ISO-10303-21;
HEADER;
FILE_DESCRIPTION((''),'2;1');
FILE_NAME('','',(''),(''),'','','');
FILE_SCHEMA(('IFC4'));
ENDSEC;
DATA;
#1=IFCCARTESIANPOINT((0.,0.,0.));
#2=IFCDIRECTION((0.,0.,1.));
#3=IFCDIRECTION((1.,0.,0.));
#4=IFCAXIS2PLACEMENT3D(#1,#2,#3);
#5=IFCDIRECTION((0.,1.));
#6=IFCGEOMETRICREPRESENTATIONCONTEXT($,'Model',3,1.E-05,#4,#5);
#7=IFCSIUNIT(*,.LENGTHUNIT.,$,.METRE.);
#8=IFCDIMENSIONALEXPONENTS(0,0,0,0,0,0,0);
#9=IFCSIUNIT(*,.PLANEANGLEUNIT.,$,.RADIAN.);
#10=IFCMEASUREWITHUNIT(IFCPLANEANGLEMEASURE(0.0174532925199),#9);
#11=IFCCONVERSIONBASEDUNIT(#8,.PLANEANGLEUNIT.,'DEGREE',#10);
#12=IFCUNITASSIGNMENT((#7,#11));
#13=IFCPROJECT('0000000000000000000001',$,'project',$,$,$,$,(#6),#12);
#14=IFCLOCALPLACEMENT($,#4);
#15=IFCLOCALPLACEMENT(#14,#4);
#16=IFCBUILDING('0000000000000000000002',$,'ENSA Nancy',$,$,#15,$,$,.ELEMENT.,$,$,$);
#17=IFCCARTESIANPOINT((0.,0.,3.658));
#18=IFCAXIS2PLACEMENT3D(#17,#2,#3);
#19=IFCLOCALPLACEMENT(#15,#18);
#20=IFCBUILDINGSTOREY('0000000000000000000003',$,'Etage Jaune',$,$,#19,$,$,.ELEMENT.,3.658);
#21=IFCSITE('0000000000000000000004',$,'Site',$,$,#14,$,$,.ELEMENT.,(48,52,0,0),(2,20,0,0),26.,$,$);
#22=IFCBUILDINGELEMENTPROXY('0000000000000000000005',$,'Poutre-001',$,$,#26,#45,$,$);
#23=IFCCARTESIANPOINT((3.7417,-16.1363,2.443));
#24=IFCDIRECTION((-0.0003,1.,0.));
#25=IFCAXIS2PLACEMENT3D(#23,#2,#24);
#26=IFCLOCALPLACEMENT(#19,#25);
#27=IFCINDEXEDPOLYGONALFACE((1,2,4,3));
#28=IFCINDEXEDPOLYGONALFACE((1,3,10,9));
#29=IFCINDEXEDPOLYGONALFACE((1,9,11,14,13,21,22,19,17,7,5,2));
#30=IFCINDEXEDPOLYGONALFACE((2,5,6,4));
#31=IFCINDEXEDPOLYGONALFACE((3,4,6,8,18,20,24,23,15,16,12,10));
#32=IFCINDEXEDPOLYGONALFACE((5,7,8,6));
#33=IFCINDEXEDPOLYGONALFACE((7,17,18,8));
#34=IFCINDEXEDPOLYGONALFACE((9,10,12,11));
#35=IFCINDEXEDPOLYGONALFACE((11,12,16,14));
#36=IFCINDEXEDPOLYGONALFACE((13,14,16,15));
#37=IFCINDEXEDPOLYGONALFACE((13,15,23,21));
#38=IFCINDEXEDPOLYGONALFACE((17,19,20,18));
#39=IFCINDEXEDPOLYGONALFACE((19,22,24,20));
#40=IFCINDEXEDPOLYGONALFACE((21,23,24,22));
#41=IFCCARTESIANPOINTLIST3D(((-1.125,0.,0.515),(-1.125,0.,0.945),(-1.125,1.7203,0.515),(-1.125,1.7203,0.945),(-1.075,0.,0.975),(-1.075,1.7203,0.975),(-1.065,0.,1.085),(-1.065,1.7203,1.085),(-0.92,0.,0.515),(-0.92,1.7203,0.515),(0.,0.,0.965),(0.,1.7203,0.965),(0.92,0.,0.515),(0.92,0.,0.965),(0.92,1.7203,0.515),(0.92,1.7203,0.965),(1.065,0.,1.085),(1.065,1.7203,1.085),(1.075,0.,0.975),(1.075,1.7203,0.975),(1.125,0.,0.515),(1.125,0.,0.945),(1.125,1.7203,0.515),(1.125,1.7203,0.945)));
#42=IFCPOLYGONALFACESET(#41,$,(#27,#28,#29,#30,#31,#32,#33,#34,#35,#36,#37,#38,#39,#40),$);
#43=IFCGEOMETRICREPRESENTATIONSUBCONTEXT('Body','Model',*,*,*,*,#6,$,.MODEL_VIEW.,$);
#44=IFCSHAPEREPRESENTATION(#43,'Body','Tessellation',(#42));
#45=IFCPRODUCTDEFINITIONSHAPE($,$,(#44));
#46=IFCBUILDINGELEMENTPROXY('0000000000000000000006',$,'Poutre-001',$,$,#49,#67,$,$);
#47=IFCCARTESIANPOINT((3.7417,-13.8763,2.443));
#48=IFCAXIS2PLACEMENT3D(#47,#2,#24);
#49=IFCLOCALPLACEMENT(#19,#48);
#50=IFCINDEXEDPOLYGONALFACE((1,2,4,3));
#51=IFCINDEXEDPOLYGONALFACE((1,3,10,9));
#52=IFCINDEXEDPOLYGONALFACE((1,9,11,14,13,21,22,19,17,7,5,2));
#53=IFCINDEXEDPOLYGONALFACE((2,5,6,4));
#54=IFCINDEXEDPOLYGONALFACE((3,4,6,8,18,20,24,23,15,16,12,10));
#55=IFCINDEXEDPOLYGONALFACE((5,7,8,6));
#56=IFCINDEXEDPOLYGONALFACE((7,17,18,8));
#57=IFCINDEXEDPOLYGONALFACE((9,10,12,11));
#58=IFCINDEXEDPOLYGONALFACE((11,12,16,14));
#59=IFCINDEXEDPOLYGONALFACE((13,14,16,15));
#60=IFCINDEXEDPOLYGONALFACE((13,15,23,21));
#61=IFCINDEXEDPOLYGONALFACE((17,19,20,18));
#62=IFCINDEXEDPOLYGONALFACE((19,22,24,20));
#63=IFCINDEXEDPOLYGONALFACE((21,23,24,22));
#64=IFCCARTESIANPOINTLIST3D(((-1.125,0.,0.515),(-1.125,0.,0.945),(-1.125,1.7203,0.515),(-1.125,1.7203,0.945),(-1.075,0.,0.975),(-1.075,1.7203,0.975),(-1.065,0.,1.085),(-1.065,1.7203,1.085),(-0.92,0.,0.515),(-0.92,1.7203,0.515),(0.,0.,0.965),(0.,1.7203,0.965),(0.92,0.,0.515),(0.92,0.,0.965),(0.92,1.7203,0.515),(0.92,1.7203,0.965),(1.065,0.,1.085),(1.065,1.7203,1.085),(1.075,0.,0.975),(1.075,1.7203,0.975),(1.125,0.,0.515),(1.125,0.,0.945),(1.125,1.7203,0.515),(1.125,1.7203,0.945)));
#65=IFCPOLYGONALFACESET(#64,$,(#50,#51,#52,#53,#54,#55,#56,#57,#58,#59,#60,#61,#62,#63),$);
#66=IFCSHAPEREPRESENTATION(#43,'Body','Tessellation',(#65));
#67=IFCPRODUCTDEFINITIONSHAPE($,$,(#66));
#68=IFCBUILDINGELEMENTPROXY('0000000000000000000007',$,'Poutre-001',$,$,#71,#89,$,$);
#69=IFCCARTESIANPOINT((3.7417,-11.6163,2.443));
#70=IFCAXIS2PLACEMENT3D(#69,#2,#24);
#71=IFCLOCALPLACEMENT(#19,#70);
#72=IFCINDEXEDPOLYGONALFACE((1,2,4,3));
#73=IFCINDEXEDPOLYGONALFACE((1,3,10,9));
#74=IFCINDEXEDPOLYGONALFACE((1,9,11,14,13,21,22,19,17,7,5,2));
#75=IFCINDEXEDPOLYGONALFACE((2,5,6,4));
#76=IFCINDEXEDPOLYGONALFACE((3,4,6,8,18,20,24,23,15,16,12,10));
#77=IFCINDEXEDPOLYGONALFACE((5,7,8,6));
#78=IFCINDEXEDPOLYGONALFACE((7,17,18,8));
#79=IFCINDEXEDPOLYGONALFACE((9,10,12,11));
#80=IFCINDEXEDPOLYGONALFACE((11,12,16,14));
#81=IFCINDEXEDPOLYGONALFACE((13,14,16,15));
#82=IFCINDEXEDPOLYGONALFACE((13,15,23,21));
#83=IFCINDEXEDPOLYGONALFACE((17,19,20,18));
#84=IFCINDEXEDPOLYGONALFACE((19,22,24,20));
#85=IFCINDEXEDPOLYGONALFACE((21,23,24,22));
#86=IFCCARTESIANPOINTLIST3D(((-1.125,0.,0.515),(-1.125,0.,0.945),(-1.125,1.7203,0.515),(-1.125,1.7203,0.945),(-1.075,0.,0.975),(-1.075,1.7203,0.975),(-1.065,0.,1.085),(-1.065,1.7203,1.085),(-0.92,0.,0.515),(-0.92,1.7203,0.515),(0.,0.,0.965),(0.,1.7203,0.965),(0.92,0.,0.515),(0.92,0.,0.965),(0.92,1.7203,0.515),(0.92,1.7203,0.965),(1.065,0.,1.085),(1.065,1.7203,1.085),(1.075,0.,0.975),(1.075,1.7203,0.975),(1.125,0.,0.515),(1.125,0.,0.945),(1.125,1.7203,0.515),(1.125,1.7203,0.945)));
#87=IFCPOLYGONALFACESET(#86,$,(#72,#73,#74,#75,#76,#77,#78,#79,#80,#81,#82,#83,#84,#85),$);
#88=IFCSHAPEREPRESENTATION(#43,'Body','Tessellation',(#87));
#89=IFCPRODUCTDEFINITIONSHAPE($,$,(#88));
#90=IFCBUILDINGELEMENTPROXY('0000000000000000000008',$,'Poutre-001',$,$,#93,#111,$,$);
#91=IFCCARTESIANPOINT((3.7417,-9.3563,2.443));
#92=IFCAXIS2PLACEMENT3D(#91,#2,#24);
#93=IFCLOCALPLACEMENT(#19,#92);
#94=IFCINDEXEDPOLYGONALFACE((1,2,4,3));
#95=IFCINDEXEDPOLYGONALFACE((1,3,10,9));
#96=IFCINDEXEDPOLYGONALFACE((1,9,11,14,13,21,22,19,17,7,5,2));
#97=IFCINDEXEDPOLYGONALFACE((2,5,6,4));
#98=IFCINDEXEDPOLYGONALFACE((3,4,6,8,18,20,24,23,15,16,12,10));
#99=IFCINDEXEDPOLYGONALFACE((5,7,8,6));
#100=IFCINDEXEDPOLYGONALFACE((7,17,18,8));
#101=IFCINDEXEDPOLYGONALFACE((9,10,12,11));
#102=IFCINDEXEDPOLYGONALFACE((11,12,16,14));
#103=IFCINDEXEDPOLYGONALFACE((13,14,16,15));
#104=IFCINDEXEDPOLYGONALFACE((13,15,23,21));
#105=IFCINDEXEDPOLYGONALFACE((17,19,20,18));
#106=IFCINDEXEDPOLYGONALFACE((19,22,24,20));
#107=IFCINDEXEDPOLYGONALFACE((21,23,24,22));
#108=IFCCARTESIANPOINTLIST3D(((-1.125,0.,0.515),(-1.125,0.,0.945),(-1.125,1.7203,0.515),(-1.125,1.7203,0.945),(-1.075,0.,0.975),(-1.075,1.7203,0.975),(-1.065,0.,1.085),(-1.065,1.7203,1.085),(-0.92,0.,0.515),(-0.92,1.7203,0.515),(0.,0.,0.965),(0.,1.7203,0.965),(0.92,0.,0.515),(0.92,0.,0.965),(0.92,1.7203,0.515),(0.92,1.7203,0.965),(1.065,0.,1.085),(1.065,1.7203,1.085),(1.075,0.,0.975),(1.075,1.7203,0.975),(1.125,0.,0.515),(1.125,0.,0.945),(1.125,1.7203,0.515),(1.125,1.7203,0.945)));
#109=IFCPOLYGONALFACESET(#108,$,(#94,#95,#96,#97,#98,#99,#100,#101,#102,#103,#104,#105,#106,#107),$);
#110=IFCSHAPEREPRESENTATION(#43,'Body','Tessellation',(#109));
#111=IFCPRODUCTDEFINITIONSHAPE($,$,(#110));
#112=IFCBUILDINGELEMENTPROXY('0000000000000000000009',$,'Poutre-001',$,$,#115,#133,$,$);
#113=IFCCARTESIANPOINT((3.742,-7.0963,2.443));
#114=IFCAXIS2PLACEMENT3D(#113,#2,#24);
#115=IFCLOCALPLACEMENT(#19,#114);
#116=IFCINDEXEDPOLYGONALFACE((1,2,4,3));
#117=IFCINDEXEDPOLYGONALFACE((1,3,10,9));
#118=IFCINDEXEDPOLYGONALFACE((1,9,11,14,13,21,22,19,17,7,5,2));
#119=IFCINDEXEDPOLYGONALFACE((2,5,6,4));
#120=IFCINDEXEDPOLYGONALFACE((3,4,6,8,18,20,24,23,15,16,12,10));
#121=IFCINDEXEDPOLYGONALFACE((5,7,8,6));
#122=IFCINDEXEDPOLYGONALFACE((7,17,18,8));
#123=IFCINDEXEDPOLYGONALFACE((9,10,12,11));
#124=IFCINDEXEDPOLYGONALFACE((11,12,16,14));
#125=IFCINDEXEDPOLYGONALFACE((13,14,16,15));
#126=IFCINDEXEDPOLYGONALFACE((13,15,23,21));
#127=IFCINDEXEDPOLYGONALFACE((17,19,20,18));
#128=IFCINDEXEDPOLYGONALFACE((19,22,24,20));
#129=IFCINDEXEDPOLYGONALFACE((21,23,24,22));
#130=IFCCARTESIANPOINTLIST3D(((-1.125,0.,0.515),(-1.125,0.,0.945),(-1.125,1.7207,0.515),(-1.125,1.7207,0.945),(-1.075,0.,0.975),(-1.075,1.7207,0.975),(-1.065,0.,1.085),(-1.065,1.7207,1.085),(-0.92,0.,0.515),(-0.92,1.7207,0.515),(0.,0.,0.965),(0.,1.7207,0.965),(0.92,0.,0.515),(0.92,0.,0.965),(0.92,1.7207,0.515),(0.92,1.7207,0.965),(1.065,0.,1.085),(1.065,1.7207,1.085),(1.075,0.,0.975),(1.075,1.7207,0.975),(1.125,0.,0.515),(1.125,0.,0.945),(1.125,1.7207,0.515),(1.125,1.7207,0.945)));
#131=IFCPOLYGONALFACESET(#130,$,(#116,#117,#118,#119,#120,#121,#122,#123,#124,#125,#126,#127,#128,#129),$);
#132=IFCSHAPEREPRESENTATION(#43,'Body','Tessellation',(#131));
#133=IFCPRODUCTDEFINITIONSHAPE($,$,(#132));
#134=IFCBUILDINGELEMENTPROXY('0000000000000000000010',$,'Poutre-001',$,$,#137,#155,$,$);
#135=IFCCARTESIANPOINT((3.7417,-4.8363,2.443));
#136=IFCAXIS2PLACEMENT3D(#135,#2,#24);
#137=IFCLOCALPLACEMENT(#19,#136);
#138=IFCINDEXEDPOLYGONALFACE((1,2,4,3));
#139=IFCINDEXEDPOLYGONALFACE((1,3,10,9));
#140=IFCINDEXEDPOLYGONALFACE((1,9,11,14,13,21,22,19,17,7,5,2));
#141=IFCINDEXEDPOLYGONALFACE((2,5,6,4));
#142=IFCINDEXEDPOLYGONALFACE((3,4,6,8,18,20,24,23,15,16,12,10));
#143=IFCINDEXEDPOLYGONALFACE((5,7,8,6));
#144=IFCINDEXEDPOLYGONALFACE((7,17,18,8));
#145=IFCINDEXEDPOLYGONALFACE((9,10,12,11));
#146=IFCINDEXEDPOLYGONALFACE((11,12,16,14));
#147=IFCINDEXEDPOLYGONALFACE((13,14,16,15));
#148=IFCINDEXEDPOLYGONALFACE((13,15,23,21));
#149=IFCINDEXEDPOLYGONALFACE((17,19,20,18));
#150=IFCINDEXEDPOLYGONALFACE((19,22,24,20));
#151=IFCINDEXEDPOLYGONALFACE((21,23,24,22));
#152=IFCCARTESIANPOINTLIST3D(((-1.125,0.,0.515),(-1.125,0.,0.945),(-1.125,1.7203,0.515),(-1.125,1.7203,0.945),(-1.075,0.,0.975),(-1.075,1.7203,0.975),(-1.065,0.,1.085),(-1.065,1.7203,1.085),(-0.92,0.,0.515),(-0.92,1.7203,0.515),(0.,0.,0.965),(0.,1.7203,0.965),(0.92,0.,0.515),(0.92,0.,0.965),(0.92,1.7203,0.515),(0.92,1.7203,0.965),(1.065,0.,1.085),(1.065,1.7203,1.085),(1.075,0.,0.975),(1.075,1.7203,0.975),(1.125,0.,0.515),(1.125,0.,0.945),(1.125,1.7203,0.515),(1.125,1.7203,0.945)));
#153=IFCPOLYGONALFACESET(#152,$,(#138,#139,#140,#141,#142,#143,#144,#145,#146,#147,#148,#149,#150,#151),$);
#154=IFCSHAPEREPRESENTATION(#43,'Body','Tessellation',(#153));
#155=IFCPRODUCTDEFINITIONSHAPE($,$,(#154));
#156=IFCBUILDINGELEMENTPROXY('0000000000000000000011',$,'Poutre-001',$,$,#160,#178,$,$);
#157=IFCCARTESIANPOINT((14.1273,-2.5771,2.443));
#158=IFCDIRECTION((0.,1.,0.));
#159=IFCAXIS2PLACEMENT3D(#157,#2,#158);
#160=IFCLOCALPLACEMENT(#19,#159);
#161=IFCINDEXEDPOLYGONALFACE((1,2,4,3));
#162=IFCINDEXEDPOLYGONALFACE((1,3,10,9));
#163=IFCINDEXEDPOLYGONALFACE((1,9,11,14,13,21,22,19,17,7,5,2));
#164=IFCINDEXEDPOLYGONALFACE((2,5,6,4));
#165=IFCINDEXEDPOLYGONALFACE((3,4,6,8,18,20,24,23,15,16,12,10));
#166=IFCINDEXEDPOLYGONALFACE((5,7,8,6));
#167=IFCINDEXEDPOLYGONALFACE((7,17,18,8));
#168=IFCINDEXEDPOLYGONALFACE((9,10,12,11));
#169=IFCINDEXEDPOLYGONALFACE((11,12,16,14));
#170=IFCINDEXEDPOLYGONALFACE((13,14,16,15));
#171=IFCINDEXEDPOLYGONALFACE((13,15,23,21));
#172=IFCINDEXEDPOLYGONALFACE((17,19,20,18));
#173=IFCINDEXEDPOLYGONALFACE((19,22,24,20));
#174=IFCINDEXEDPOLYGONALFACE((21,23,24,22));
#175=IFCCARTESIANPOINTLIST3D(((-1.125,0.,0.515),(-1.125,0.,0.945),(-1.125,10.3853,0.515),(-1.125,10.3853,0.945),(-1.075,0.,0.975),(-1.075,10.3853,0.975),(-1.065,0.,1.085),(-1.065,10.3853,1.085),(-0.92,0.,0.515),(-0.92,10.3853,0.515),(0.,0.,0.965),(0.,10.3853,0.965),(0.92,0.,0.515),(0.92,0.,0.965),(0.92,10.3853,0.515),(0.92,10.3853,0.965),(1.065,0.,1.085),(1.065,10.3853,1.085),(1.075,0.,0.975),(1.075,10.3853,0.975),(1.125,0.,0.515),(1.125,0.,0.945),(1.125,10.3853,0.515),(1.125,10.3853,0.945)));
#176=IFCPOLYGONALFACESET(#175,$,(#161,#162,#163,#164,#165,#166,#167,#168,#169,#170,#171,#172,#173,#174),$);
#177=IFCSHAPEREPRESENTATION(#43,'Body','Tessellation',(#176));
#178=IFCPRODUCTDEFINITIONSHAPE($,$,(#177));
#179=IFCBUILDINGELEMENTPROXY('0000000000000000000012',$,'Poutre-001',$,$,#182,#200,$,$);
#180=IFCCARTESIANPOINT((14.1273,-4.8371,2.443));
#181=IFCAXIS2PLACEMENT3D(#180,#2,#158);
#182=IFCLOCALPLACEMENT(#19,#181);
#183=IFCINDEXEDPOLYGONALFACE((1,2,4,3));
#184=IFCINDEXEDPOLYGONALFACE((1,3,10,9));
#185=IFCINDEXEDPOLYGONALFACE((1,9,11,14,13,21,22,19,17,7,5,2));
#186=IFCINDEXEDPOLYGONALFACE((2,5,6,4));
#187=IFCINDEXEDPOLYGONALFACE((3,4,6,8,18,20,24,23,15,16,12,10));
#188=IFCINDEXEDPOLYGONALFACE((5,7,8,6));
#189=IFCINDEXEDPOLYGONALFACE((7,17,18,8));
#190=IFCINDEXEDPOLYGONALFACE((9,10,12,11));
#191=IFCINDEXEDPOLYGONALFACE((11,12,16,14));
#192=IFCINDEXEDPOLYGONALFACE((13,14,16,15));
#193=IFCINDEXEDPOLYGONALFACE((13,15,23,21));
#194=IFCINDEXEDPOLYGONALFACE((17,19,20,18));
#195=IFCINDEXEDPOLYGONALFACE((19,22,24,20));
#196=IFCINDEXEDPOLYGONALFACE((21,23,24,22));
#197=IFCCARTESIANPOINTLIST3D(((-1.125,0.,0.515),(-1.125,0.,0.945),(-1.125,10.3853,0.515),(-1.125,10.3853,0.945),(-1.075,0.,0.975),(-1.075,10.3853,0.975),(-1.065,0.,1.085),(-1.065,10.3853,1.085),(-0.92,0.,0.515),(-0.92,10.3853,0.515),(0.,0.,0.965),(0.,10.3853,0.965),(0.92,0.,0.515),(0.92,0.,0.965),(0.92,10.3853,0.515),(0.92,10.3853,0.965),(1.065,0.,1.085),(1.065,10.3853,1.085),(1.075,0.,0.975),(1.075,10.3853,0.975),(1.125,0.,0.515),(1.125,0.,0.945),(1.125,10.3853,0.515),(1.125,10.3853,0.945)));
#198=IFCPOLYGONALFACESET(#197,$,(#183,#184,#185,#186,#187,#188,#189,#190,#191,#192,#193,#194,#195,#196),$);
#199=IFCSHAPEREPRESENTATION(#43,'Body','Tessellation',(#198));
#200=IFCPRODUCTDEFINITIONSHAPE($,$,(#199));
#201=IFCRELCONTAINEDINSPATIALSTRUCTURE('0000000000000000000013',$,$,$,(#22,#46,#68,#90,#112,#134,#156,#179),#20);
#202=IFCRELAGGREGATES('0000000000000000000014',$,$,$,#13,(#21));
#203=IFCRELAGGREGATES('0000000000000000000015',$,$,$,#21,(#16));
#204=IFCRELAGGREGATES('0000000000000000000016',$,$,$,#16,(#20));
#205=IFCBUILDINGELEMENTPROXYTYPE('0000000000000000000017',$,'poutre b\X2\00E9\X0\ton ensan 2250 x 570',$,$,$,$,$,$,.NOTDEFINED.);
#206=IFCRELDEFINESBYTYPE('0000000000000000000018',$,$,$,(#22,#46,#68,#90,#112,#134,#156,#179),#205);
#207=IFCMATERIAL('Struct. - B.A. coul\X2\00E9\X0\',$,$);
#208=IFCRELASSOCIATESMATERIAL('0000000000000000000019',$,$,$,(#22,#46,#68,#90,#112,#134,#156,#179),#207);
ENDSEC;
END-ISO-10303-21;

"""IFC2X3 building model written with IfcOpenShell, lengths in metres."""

from ifc_helpers import new_model, entity, si_unit, converted_unit, direction, frame, origin_with_axes, place, context, subcontext, project, spatial, polyline, outline, extrude, material, type_object, element, save


model = new_model("IFC2X3")

# Units and contexts
model_context = context("Model", 3, precision=1e-05, world=origin_with_axes(), true_north=direction((0.0, 1.0)))
body_context = subcontext(model_context, "Body", "Model", "MODEL_VIEW")
ifc_project = project(units=[si_unit("LENGTHUNIT", "METRE"), converted_unit("PLANEANGLEUNIT", "DEGREE", entity("IfcPlaneAngleMeasure", 0.0174532925199), si_unit("PLANEANGLEUNIT", "RADIAN"), dimensions=[0, 0, 0, 0, 0, 0, 0])], contexts=[model_context])

# Site, building, storey
site_placement = place(None, origin_with_axes())
site = spatial("IfcSite", under=ifc_project, at=site_placement, Name="Site", CompositionType="ELEMENT", RefLatitude=(48, 52, 0, 0), RefLongitude=(2, 20, 0, 0), RefElevation=26.0)
building_placement = place(site_placement, origin_with_axes())
building = spatial("IfcBuilding", under=site, at=building_placement, Name="ENSA Nancy", CompositionType="ELEMENT")
storey_placement = place(building_placement, frame((0.0, 0.0, 3.658), z_axis=(0.0, 0.0, 1.0), x_axis=(1.0, 0.0, 0.0)))
storey = spatial("IfcBuildingStorey", under=building, at=storey_placement, Name="Etage Jaune", CompositionType="ELEMENT", Elevation=3.658)

# Building element proxies
ifc_material_1 = material(Name="Struct. - B.A. coulé")
building_element_proxy_type_1 = type_object("IfcBuildingElementProxyType", Name="poutre béton ensan 2250 x 570", PredefinedType="NOTDEFINED")
for number, where, z_axis, x_axis, name in (
    (1, (3.7417, -16.1363, 2.443), (0.0, 0.0, 1.0), (-0.0003, 1.0, 0.0), "Poutre-001"),
    (2, (3.7417, -13.8763, 2.443), (0.0, 0.0, 1.0), (-0.0003, 1.0, 0.0), "Poutre-001"),
    (3, (3.7417, -11.6163, 2.443), (0.0, 0.0, 1.0), (-0.0003, 1.0, 0.0), "Poutre-001"),
    (4, (3.7417, -9.3563, 2.443), (0.0, 0.0, 1.0), (-0.0003, 1.0, 0.0), "Poutre-001"),
):
    element("IfcBuildingElementProxy", number, at=place(storey_placement, frame(where, z_axis=z_axis, x_axis=x_axis)), inside=storey, type_object=building_element_proxy_type_1, material=ifc_material_1, Name=name, context=body_context, shape_type="SweptSolid", body=[
        extrude(outline(polyline([(-1.065, 1.085), (-1.075, 0.975), (-1.125, 0.945), (-1.125, 0.515), (-0.92, 0.515), (0.0, 0.965), (0.92, 0.965), (0.92, 0.515), (1.125, 0.515), (1.125, 0.945), (1.075, 0.975), (1.065, 1.085), (-1.065, 1.085)])), frame((0.0, 1.7203, 0.0), z_axis=(0.0, -1.0, 0.0), x_axis=(1.0, 0.0, 0.0)), (0.0, 0.0, 1.0), 1.7203),
    ])
proxy_1_placement = place(storey_placement, frame((3.742, -7.0963, 2.443), z_axis=(0.0, 0.0, 1.0), x_axis=(-0.0003, 1.0, 0.0)))
element("IfcBuildingElementProxy", 5, at=proxy_1_placement, inside=storey, type_object=building_element_proxy_type_1, material=ifc_material_1, Name="Poutre-001", context=body_context, shape_type="SweptSolid", body=[
    extrude(outline(polyline([(-1.065, 1.085), (-1.075, 0.975), (-1.125, 0.945), (-1.125, 0.515), (-0.92, 0.515), (0.0, 0.965), (0.92, 0.965), (0.92, 0.515), (1.125, 0.515), (1.125, 0.945), (1.075, 0.975), (1.065, 1.085), (-1.065, 1.085)])), frame((0.0, 1.7207, 0.0), z_axis=(0.0, -1.0, 0.0), x_axis=(1.0, 0.0, 0.0)), (0.0, 0.0, 1.0), 1.7207),
])
proxy_2_placement = place(storey_placement, frame((3.7417, -4.8363, 2.443), z_axis=(0.0, 0.0, 1.0), x_axis=(-0.0003, 1.0, 0.0)))
element("IfcBuildingElementProxy", 6, at=proxy_2_placement, inside=storey, type_object=building_element_proxy_type_1, material=ifc_material_1, Name="Poutre-001", context=body_context, shape_type="SweptSolid", body=[
    extrude(outline(polyline([(-1.065, 1.085), (-1.075, 0.975), (-1.125, 0.945), (-1.125, 0.515), (-0.92, 0.515), (0.0, 0.965), (0.92, 0.965), (0.92, 0.515), (1.125, 0.515), (1.125, 0.945), (1.075, 0.975), (1.065, 1.085), (-1.065, 1.085)])), frame((0.0, 1.7203, 0.0), z_axis=(0.0, -1.0, 0.0), x_axis=(1.0, 0.0, 0.0)), (0.0, 0.0, 1.0), 1.7203),
])
for number, where, z_axis, x_axis, name in (
    (7, (14.1273, -2.5771, 2.443), (0.0, 0.0, 1.0), (0.0, 1.0, 0.0), "Poutre-001"),
    (8, (14.1273, -4.8371, 2.443), (0.0, 0.0, 1.0), (0.0, 1.0, 0.0), "Poutre-001"),
):
    element("IfcBuildingElementProxy", number, at=place(storey_placement, frame(where, z_axis=z_axis, x_axis=x_axis)), inside=storey, type_object=building_element_proxy_type_1, material=ifc_material_1, Name=name, context=body_context, shape_type="SweptSolid", body=[
        extrude(outline(polyline([(-1.065, 1.085), (-1.075, 0.975), (-1.125, 0.945), (-1.125, 0.515), (-0.92, 0.515), (0.0, 0.965), (0.92, 0.965), (0.92, 0.515), (1.125, 0.515), (1.125, 0.945), (1.075, 0.975), (1.065, 1.085), (-1.065, 1.085)])), frame((0.0, 10.3853, 0.0), z_axis=(0.0, -1.0, 0.0), x_axis=(1.0, 0.0, 0.0)), (0.0, 0.0, 1.0), 10.3853),
    ])

save(model, "model.ifc")
